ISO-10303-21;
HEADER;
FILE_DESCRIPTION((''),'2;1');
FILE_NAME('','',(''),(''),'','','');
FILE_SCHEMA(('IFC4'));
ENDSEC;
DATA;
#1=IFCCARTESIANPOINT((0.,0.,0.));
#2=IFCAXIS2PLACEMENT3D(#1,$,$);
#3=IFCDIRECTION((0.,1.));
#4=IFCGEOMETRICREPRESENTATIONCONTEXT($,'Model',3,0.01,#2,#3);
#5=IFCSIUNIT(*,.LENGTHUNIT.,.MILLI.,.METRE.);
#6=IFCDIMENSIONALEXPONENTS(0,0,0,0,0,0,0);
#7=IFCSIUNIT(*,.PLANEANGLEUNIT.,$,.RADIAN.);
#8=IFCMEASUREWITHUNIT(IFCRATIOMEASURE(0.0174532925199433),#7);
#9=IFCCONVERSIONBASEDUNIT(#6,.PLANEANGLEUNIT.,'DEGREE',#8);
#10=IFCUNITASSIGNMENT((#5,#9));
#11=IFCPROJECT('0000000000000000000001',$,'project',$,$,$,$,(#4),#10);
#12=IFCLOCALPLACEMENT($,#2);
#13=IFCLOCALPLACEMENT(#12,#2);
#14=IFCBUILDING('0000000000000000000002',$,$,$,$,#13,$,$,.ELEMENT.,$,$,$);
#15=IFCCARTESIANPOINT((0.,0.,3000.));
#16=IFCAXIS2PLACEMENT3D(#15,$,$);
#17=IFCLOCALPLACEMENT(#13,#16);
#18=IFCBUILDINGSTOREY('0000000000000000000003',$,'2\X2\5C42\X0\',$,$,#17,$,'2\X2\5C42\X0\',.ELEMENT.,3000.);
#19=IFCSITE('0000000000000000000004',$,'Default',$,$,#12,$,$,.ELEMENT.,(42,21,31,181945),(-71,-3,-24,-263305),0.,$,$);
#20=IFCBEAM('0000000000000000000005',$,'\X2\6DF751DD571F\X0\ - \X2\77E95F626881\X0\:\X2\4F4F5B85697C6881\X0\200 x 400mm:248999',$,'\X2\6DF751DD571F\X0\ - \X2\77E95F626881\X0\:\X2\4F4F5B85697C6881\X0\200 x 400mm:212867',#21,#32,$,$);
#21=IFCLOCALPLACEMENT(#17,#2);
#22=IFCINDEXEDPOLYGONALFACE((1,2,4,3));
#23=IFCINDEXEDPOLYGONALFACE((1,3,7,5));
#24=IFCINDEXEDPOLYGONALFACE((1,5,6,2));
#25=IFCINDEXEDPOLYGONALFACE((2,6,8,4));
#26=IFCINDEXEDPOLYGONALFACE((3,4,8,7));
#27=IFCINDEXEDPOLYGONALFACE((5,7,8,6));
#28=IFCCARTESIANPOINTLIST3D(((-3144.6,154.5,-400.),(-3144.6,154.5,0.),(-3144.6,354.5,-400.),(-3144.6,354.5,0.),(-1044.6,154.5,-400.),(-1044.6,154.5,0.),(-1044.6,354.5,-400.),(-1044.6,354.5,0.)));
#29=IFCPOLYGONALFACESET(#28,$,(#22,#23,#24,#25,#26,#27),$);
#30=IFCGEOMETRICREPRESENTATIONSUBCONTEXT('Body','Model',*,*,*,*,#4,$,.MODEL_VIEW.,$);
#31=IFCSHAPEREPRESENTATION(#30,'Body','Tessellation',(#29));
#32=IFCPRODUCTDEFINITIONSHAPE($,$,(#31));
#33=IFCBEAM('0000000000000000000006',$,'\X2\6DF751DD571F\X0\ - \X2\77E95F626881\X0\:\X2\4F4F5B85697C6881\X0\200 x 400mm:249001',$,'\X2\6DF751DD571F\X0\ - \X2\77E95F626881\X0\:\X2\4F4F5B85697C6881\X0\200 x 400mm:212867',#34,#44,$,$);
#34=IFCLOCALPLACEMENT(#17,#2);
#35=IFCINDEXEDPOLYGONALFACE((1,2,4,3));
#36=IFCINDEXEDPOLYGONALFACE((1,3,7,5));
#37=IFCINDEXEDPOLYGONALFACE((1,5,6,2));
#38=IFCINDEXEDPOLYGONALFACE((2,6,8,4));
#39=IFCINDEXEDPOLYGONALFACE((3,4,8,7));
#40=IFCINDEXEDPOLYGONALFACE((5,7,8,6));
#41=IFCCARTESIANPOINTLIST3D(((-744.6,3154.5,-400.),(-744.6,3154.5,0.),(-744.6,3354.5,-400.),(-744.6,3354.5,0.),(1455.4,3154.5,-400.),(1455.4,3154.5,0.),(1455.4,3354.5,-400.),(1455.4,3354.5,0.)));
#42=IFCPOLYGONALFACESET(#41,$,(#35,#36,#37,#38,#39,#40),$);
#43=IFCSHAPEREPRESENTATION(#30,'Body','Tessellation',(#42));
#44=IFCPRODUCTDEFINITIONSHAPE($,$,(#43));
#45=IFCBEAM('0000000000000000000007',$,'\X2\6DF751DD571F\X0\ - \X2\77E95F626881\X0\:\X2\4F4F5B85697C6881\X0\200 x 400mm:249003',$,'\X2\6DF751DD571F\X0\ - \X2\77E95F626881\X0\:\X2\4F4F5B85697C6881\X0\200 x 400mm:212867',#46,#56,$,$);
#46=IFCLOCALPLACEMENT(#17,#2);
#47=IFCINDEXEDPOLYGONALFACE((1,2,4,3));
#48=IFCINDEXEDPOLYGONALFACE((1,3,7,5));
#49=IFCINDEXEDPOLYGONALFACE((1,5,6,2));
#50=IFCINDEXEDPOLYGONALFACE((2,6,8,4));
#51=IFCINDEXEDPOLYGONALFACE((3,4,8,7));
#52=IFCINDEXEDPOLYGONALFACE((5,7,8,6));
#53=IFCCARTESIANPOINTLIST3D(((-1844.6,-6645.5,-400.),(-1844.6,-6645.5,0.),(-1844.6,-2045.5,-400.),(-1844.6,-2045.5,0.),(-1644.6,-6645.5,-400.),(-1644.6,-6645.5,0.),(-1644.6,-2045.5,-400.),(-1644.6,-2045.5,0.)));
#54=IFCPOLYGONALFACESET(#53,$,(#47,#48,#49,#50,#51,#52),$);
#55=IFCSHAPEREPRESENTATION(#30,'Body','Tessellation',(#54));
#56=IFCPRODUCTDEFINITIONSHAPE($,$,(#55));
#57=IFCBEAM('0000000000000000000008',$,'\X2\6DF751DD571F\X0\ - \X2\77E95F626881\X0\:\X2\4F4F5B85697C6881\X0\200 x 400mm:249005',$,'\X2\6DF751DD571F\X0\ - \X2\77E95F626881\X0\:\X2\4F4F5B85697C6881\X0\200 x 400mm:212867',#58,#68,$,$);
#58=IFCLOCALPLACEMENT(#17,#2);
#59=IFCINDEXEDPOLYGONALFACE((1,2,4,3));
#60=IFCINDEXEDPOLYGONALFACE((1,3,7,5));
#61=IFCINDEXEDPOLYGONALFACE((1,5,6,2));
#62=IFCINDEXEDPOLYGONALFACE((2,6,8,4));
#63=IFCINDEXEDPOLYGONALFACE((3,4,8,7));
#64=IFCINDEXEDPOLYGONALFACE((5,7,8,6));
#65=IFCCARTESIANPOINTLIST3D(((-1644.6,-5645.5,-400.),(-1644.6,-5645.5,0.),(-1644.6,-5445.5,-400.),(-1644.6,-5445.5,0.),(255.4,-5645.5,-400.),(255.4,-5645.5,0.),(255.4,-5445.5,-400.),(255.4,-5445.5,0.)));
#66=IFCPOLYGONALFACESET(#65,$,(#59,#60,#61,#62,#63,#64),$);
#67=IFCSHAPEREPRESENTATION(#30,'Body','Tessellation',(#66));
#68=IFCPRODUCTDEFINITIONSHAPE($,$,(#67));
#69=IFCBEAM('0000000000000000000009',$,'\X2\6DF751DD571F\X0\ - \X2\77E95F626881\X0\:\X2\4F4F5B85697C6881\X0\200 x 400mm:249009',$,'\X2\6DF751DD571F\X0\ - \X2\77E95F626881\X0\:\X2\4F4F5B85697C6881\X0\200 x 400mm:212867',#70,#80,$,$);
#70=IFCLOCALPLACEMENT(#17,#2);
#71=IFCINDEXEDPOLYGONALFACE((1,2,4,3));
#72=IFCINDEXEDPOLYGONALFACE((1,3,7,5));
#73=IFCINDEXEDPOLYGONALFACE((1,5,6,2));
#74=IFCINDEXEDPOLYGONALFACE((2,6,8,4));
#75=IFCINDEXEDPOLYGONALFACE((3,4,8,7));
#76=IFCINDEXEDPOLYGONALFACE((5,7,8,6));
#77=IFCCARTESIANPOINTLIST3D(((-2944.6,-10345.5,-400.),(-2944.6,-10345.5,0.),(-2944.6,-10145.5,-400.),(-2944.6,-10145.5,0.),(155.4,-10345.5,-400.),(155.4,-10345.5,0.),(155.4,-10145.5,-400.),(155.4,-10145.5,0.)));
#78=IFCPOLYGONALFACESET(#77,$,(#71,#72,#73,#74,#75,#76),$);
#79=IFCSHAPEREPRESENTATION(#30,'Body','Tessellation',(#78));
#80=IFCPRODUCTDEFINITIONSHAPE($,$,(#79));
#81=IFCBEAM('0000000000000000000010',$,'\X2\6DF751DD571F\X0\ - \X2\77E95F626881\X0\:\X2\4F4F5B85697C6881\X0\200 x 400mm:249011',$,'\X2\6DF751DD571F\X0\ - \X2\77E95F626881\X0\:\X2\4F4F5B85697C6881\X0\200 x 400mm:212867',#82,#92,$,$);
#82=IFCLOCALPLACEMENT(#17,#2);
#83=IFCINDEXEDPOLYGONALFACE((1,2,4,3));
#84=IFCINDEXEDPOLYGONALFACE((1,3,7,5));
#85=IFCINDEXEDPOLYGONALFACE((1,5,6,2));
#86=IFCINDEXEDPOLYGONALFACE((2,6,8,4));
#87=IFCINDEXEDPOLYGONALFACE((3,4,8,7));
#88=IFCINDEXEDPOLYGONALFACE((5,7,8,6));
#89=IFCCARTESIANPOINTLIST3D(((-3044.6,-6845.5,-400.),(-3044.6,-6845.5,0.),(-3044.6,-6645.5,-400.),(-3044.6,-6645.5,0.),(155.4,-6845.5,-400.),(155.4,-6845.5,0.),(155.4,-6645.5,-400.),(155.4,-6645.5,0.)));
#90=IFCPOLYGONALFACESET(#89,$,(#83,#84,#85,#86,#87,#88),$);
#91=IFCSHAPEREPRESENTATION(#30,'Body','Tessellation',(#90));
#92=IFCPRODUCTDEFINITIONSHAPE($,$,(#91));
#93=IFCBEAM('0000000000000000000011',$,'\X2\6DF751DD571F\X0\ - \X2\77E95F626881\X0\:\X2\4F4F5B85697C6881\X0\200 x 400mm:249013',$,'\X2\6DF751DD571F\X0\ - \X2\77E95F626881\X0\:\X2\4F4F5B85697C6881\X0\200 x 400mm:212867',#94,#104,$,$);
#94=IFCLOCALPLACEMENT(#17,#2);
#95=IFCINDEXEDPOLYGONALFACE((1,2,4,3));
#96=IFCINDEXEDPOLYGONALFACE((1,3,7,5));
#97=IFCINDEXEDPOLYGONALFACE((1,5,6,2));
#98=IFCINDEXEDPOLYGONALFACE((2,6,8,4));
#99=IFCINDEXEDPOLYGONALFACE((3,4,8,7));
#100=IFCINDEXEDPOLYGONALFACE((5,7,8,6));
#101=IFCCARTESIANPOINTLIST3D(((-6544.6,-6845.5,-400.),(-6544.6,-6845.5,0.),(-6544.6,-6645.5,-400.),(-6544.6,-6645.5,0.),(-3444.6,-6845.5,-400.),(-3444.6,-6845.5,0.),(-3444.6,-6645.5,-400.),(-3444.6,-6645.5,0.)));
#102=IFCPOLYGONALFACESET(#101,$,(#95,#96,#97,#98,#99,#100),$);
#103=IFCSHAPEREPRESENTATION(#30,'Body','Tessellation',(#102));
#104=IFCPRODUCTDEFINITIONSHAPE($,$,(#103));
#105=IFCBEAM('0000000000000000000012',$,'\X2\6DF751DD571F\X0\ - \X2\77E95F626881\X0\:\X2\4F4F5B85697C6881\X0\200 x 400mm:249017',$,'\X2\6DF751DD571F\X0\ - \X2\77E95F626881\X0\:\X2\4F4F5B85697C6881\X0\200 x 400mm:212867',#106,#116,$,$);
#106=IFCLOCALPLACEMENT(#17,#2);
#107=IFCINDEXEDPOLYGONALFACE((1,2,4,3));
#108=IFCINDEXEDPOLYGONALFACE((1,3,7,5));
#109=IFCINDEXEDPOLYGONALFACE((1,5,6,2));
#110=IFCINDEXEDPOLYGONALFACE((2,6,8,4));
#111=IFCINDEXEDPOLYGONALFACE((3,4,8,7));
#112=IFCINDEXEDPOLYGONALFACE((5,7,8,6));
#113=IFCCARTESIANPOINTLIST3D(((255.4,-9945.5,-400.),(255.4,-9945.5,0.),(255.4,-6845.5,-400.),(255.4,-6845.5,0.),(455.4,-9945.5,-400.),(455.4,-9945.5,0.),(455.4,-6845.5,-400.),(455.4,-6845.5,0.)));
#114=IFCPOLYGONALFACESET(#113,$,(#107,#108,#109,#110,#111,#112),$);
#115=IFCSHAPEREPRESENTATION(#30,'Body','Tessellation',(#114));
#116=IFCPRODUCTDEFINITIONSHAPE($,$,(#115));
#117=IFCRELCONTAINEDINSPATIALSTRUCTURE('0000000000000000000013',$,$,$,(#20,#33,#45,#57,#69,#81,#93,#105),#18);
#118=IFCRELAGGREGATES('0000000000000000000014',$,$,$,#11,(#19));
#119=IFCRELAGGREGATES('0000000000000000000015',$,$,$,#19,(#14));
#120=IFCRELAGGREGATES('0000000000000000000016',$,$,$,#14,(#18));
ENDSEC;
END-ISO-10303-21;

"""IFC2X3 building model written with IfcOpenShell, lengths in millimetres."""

from ifc_helpers import new_model, entity, si_unit, converted_unit, direction, frame, frame_2d, origin, origin_2d_with_axis, place, context, subcontext, project, spatial, rectangle, extrude, element, save


model = new_model("IFC2X3")

# Units and contexts
model_context = context("Model", 3, precision=0.01, world=origin(), true_north=direction((0.0, 1.0)))
body_context = subcontext(model_context, "Body", "Model", "MODEL_VIEW")
ifc_project = project(units=[si_unit("LENGTHUNIT", "METRE", prefix="MILLI"), converted_unit("PLANEANGLEUNIT", "DEGREE", entity("IfcRatioMeasure", 0.0174532925199433), si_unit("PLANEANGLEUNIT", "RADIAN"), dimensions=[0, 0, 0, 0, 0, 0, 0])], contexts=[model_context])

# Site, building, storey
site_placement = place(None, origin())
site = spatial("IfcSite", under=ifc_project, at=site_placement, Name="Default", CompositionType="ELEMENT", RefLatitude=(42, 21, 31, 181945), RefLongitude=(-71, -3, -24, -263305), RefElevation=0.0)
building_placement = place(site_placement, origin())
building = spatial("IfcBuilding", under=site, at=building_placement, CompositionType="ELEMENT")
storey_placement = place(building_placement, frame((0.0, 0.0, 3000.0)))
storey = spatial("IfcBuildingStorey", under=building, at=storey_placement, Name="2层", LongName="2层", CompositionType="ELEMENT", Elevation=3000.0)

# Beams
beam_1_placement = place(storey_placement, frame((-3244.6, 254.5, 0.0)))
element("IfcBeam", 1, at=beam_1_placement, inside=storey, Name="混凝土 - 矩形梁:住宅楼梁200 x 400mm:248999", ObjectType="混凝土 - 矩形梁:住宅楼梁200 x 400mm:212867", context=body_context, shape_type="SweptSolid", body=[
    extrude(rectangle(XDim=400.0, YDim=200.0, at=frame_2d((0.0, 0.0), x_axis=(1.0, 0.0))), frame((100.0, 0.0, -200.0), z_axis=(1.0, 0.0, 0.0), x_axis=(0.0, 0.0, -1.0)), (0.0, 0.0, 1.0), 2100.0),
])
beam_2_placement = place(storey_placement, frame((-944.6, 3254.5, 0.0)))
element("IfcBeam", 2, at=beam_2_placement, inside=storey, Name="混凝土 - 矩形梁:住宅楼梁200 x 400mm:249001", ObjectType="混凝土 - 矩形梁:住宅楼梁200 x 400mm:212867", context=body_context, shape_type="SweptSolid", body=[
    extrude(rectangle(XDim=400.0, YDim=200.0, at=frame_2d((0.0, 0.0), x_axis=(1.0, 0.0))), frame((200.0, 0.0, -200.0), z_axis=(1.0, 0.0, 0.0), x_axis=(0.0, 0.0, -1.0)), (0.0, 0.0, 1.0), 2200.0),
])
beam_3_placement = place(storey_placement, frame((-1744.6, -1945.5, 0.0), z_axis=(0.0, 0.0, 1.0), x_axis=(0.0, -1.0, 0.0)))
element("IfcBeam", 3, at=beam_3_placement, inside=storey, Name="混凝土 - 矩形梁:住宅楼梁200 x 400mm:249003", ObjectType="混凝土 - 矩形梁:住宅楼梁200 x 400mm:212867", context=body_context, shape_type="SweptSolid", body=[
    extrude(rectangle(XDim=400.0, YDim=200.0, at=origin_2d_with_axis()), frame((100.0, 0.0, -200.0), z_axis=(1.0, 0.0, 0.0), x_axis=(0.0, 0.0, -1.0)), (0.0, 0.0, 1.0), 4600.0),
])
beam_4_placement = place(storey_placement, frame((-1744.6, -5545.5, 0.0)))
element("IfcBeam", 4, at=beam_4_placement, inside=storey, Name="混凝土 - 矩形梁:住宅楼梁200 x 400mm:249005", ObjectType="混凝土 - 矩形梁:住宅楼梁200 x 400mm:212867", context=body_context, shape_type="SweptSolid", body=[
    extrude(rectangle(XDim=400.0, YDim=200.0, at=frame_2d((0.0, 0.0), x_axis=(1.0, 0.0))), frame((100.0, 0.0, -200.0), z_axis=(1.0, 0.0, 0.0), x_axis=(0.0, 0.0, -1.0)), (0.0, 0.0, 1.0), 1900.0),
])
beam_5_placement = place(storey_placement, frame((-2944.6, -10245.5, 0.0)))
element("IfcBeam", 5, at=beam_5_placement, inside=storey, Name="混凝土 - 矩形梁:住宅楼梁200 x 400mm:249009", ObjectType="混凝土 - 矩形梁:住宅楼梁200 x 400mm:212867", context=body_context, shape_type="SweptSolid", body=[
    extrude(rectangle(XDim=400.0, YDim=200.0, at=frame_2d((0.0, 0.0), x_axis=(1.0, 0.0))), frame((0.0, 0.0, -200.0), z_axis=(1.0, 0.0, 0.0), x_axis=(0.0, 0.0, -1.0)), (0.0, 0.0, 1.0), 3100.0),
])
beam_6_placement = place(storey_placement, frame((-3244.6, -6745.5, 0.0)))
element("IfcBeam", 6, at=beam_6_placement, inside=storey, Name="混凝土 - 矩形梁:住宅楼梁200 x 400mm:249011", ObjectType="混凝土 - 矩形梁:住宅楼梁200 x 400mm:212867", context=body_context, shape_type="SweptSolid", body=[
    extrude(rectangle(XDim=400.0, YDim=200.0, at=frame_2d((0.0, 0.0), x_axis=(1.0, 0.0))), frame((200.0, 0.0, -200.0), z_axis=(1.0, 0.0, 0.0), x_axis=(0.0, 0.0, -1.0)), (0.0, 0.0, 1.0), 3200.0),
])
beam_7_placement = place(storey_placement, frame((-3244.6, -6745.5, 0.0), z_axis=(0.0, 0.0, 1.0), x_axis=(-1.0, 0.0, 0.0)))
element("IfcBeam", 7, at=beam_7_placement, inside=storey, Name="混凝土 - 矩形梁:住宅楼梁200 x 400mm:249013", ObjectType="混凝土 - 矩形梁:住宅楼梁200 x 400mm:212867", context=body_context, shape_type="SweptSolid", body=[
    extrude(rectangle(XDim=400.0, YDim=200.0, at=frame_2d((0.0, 0.0), x_axis=(1.0, 0.0))), frame((200.0, 0.0, -200.0), z_axis=(1.0, 0.0, 0.0), x_axis=(0.0, 0.0, -1.0)), (0.0, 0.0, 1.0), 3100.0),
])
beam_8_placement = place(storey_placement, frame((355.4, -10145.5, 0.0), z_axis=(0.0, 0.0, 1.0), x_axis=(0.0, 1.0, 0.0)))
element("IfcBeam", 8, at=beam_8_placement, inside=storey, Name="混凝土 - 矩形梁:住宅楼梁200 x 400mm:249017", ObjectType="混凝土 - 矩形梁:住宅楼梁200 x 400mm:212867", context=body_context, shape_type="SweptSolid", body=[
    extrude(rectangle(XDim=400.0, YDim=200.0, at=frame_2d((0.0, 0.0), x_axis=(1.0, 0.0))), frame((200.0, 0.0, -200.0), z_axis=(1.0, 0.0, 0.0), x_axis=(0.0, 0.0, -1.0)), (0.0, 0.0, 1.0), 3100.0),
])

save(model, "model.ifc")
